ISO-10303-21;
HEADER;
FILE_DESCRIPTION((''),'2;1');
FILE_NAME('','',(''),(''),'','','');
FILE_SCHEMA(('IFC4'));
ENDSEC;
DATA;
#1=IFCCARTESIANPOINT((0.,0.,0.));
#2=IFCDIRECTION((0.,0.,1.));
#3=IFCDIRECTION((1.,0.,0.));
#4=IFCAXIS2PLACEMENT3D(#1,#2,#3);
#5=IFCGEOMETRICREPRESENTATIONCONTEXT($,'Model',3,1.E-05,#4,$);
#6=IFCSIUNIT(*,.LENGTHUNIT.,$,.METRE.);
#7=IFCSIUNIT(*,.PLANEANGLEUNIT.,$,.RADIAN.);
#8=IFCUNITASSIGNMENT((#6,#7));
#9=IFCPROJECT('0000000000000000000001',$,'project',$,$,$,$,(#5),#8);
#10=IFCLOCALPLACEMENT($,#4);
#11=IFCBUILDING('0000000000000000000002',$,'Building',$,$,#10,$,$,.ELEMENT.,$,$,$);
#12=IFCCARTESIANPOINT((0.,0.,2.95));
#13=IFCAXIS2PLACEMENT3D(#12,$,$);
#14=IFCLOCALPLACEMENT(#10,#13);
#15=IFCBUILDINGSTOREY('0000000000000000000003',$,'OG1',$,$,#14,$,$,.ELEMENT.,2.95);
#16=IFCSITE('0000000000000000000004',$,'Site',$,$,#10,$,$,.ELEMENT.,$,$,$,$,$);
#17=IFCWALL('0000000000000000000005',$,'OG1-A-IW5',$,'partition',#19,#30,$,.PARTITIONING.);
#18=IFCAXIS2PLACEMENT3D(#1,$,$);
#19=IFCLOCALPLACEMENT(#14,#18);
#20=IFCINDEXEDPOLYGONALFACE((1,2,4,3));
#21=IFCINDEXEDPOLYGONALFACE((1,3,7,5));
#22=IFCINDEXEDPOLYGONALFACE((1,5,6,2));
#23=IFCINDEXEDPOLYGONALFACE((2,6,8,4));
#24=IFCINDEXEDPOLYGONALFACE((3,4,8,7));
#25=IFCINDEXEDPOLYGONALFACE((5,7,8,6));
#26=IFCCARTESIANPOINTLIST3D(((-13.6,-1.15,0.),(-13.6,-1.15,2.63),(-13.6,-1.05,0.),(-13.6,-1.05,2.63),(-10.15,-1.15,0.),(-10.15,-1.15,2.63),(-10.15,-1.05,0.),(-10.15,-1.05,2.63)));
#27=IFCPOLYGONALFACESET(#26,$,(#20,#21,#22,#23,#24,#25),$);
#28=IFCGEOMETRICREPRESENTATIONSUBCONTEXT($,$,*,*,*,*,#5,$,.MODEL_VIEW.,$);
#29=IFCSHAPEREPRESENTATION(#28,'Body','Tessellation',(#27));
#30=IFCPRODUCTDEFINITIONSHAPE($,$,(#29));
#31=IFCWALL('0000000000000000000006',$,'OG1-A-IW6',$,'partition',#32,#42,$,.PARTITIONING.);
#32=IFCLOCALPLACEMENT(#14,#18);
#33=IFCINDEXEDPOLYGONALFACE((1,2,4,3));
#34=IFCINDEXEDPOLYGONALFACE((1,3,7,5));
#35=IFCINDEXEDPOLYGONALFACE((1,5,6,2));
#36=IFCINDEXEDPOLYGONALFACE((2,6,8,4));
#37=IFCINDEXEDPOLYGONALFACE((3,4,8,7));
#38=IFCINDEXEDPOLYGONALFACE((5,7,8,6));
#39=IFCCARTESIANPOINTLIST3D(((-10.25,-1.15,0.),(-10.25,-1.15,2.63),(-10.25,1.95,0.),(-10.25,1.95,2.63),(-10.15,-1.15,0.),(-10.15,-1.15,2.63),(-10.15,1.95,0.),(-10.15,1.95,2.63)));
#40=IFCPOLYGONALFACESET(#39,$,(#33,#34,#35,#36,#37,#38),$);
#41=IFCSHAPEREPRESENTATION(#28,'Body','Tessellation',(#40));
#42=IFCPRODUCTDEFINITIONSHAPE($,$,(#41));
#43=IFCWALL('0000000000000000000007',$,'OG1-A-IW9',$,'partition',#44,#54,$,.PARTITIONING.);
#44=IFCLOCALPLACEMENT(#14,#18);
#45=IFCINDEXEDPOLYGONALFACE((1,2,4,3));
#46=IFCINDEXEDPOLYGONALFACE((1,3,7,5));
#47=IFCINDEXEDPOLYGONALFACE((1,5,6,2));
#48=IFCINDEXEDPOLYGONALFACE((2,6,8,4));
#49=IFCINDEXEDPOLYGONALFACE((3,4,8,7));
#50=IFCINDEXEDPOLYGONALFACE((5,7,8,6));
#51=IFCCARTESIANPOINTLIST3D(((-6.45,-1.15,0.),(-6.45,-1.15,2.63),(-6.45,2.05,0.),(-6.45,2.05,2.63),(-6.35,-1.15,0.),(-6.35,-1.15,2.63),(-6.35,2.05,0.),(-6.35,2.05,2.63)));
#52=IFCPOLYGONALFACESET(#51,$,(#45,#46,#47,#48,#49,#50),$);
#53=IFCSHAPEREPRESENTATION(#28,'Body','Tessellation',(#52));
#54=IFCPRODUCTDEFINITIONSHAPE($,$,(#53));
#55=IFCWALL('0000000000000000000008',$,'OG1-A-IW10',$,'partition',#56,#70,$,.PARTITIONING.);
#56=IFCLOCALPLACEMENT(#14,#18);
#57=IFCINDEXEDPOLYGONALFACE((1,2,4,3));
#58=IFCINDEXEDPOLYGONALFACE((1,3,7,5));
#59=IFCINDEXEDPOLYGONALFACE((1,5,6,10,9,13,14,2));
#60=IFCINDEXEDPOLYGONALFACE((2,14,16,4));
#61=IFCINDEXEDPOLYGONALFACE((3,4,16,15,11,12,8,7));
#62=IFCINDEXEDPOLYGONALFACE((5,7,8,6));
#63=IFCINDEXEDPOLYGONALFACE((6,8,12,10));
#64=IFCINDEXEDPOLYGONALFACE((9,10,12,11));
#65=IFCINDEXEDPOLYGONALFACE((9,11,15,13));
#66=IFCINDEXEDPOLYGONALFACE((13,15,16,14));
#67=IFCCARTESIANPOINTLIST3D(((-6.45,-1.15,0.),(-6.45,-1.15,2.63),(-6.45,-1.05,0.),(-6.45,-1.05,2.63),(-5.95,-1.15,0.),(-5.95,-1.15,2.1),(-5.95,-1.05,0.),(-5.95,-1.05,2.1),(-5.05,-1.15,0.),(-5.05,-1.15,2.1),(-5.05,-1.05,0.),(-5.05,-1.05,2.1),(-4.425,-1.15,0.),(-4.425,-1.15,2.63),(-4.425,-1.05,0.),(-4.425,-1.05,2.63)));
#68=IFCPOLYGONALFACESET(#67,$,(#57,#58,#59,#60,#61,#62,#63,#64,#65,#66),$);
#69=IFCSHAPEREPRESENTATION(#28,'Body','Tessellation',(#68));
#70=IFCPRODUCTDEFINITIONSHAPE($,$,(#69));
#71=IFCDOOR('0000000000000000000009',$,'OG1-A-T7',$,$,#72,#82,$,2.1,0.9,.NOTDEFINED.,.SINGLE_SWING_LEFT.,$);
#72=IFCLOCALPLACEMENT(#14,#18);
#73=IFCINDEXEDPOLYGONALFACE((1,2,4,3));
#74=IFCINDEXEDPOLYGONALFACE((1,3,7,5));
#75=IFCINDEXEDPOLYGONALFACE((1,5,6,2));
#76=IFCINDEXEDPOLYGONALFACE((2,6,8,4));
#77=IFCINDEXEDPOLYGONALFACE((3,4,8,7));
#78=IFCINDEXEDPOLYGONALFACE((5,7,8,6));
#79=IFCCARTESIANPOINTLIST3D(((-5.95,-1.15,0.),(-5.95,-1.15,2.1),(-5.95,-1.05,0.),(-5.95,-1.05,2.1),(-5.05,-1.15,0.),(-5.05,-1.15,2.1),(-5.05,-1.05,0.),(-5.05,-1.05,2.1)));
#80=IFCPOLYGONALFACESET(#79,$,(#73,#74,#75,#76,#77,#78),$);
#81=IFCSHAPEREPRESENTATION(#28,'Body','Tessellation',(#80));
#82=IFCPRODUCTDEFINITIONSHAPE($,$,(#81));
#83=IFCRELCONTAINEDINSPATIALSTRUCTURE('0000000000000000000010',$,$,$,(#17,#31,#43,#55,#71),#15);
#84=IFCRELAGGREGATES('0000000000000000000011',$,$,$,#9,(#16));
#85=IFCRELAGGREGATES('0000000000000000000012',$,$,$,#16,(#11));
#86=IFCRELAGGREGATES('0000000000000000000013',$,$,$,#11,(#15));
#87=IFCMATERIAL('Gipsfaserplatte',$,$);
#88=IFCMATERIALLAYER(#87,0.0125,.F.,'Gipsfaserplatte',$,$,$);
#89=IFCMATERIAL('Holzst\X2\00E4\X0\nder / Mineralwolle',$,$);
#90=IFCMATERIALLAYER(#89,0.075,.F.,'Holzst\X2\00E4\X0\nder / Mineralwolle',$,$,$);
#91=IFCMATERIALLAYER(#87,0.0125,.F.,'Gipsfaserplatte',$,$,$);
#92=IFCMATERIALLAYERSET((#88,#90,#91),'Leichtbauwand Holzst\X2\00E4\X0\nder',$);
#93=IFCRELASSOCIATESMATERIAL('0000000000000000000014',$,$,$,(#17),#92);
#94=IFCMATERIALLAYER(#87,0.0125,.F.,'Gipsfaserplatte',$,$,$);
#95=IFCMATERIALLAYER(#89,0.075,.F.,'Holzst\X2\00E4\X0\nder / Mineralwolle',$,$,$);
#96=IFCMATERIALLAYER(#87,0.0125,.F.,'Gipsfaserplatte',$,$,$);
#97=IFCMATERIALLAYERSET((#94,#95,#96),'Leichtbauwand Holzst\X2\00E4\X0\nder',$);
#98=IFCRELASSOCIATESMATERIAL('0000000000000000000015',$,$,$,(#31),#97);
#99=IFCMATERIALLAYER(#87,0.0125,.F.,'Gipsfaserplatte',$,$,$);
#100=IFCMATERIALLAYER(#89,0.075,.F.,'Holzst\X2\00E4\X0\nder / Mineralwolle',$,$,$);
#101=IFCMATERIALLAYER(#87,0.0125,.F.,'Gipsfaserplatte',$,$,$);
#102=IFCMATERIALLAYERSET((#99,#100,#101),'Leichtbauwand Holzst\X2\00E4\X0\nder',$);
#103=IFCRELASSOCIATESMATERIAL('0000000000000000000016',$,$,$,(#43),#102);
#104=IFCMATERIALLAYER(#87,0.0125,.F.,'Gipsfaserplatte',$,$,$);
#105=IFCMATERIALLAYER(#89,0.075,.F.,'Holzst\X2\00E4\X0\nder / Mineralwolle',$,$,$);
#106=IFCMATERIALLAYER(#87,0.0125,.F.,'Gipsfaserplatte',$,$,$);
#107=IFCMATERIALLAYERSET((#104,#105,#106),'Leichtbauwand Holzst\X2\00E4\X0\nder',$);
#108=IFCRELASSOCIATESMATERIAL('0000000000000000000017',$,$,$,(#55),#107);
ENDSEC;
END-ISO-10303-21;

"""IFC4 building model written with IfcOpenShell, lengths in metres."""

from ifc_helpers import new_model, si_unit, frame, frame_2d, origin, origin_with_axes, place, context, subcontext, project, spatial, rectangle, extrude, material, layer, layer_set, element, fill, save


model = new_model("IFC4")

# Units and contexts
model_context = context("Model", 3, precision=1e-05, world=origin_with_axes())
sub_context = subcontext(model_context, None, None, "MODEL_VIEW")
ifc_project = project(units=[si_unit("LENGTHUNIT", "METRE"), si_unit("PLANEANGLEUNIT", "RADIAN")], contexts=[model_context])

# Site, building, storey
placement = place(None, origin_with_axes())
site = spatial("IfcSite", under=ifc_project, at=placement, Name="Site", CompositionType="ELEMENT")
building = spatial("IfcBuilding", under=site, at=placement, Name="Building", CompositionType="ELEMENT")
storey_placement = place(placement, frame((0.0, 0.0, 2.95)))
storey = spatial("IfcBuildingStorey", under=building, at=storey_placement, Name="OG1", CompositionType="ELEMENT", Elevation=2.95)

# Shared definitions
ifc_material_1 = material(Name="Gipsfaserplatte")

# Walls
ifc_layer_1 = layer(ifc_material_1, 0.0125, ventilated=False, Name="Gipsfaserplatte")
ifc_material_2 = material(Name="Holzständer / Mineralwolle")
ifc_layer_2 = layer(ifc_material_2, 0.075, ventilated=False, Name="Holzständer / Mineralwolle")
ifc_layer_3 = layer(ifc_material_1, 0.0125, ventilated=False, Name="Gipsfaserplatte")
ifc_layer_set_1 = layer_set([ifc_layer_1, ifc_layer_2, ifc_layer_3], Name="Leichtbauwand Holzständer")
wall_1_placement = place(storey_placement, frame((-13.6, -1.1, 0.0), z_axis=(0.0, 0.0, 1.0), x_axis=(1.0, 0.0, 0.0)))
element("IfcWall", 1, at=wall_1_placement, inside=storey, material=ifc_layer_set_1, Name="OG1-A-IW5", ObjectType="partition", PredefinedType="PARTITIONING", context=sub_context, shape_type="SweptSolid", body=[
    extrude(rectangle(XDim=3.45, YDim=0.1, at=frame_2d((1.725, 0.0))), origin(), (0.0, 0.0, 1.0), 2.63),
])
ifc_layer_4 = layer(ifc_material_1, 0.0125, ventilated=False, Name="Gipsfaserplatte")
ifc_layer_5 = layer(ifc_material_2, 0.075, ventilated=False, Name="Holzständer / Mineralwolle")
ifc_layer_6 = layer(ifc_material_1, 0.0125, ventilated=False, Name="Gipsfaserplatte")
ifc_layer_set_2 = layer_set([ifc_layer_4, ifc_layer_5, ifc_layer_6], Name="Leichtbauwand Holzständer")
wall_2_placement = place(storey_placement, frame((-10.2, -1.15, 0.0), z_axis=(0.0, 0.0, 1.0), x_axis=(0.0, 1.0, 0.0)))
element("IfcWall", 2, at=wall_2_placement, inside=storey, material=ifc_layer_set_2, Name="OG1-A-IW6", ObjectType="partition", PredefinedType="PARTITIONING", context=sub_context, shape_type="SweptSolid", body=[
    extrude(rectangle(XDim=3.1, YDim=0.1, at=frame_2d((1.55, 0.0))), origin(), (0.0, 0.0, 1.0), 2.63),
])
ifc_layer_7 = layer(ifc_material_1, 0.0125, ventilated=False, Name="Gipsfaserplatte")
ifc_layer_8 = layer(ifc_material_2, 0.075, ventilated=False, Name="Holzständer / Mineralwolle")
ifc_layer_9 = layer(ifc_material_1, 0.0125, ventilated=False, Name="Gipsfaserplatte")
ifc_layer_set_3 = layer_set([ifc_layer_7, ifc_layer_8, ifc_layer_9], Name="Leichtbauwand Holzständer")
wall_3_placement = place(storey_placement, frame((-6.4, -1.15, 0.0), z_axis=(0.0, 0.0, 1.0), x_axis=(0.0, 1.0, 0.0)))
element("IfcWall", 3, at=wall_3_placement, inside=storey, material=ifc_layer_set_3, Name="OG1-A-IW9", ObjectType="partition", PredefinedType="PARTITIONING", context=sub_context, shape_type="SweptSolid", body=[
    extrude(rectangle(XDim=3.2, YDim=0.1, at=frame_2d((1.6, 0.0))), origin(), (0.0, 0.0, 1.0), 2.63),
])

# Wall, opening, door
ifc_layer_10 = layer(ifc_material_1, 0.0125, ventilated=False, Name="Gipsfaserplatte")
ifc_layer_11 = layer(ifc_material_2, 0.075, ventilated=False, Name="Holzständer / Mineralwolle")
ifc_layer_12 = layer(ifc_material_1, 0.0125, ventilated=False, Name="Gipsfaserplatte")
ifc_layer_set_4 = layer_set([ifc_layer_10, ifc_layer_11, ifc_layer_12], Name="Leichtbauwand Holzständer")
wall_4_placement = place(storey_placement, frame((-6.45, -1.1, 0.0), z_axis=(0.0, 0.0, 1.0), x_axis=(1.0, 0.0, 0.0)))
wall_4 = element("IfcWall", 4, at=wall_4_placement, inside=storey, material=ifc_layer_set_4, Name="OG1-A-IW10", ObjectType="partition", PredefinedType="PARTITIONING", context=sub_context, shape_type="SweptSolid", body=[
    extrude(rectangle(XDim=2.025, YDim=0.1, at=frame_2d((1.0125, 0.0))), origin(), (0.0, 0.0, 1.0), 2.63),
])
opening_1_placement = place(wall_4_placement, frame((0.95, 0.1, 0.0), z_axis=(0.0, -1.0, 0.0), x_axis=(1.0, 0.0, 0.0)))
opening_1 = element("IfcOpeningElement", 5, at=opening_1_placement, cuts=wall_4, PredefinedType="OPENING", context=sub_context, shape_type="SweptSolid", body=[
    extrude(rectangle(XDim=0.9, YDim=2.1, at=frame_2d((0.0, 1.05))), origin(), (0.0, 0.0, 1.0), 0.2),
])
door_1_placement = place(wall_4_placement, frame((0.95, 0.05, 0.0), z_axis=(0.0, -1.0, 0.0), x_axis=(1.0, 0.0, 0.0)))
door_1 = element("IfcDoor", 6, at=door_1_placement, inside=storey, Name="OG1-A-T7", OperationType="SINGLE_SWING_LEFT", OverallHeight=2.1, OverallWidth=0.9, PredefinedType="NOTDEFINED", context=sub_context, shape_type="SweptSolid", body=[
    extrude(rectangle(XDim=0.9, YDim=2.1, at=frame_2d((0.0, 1.05))), origin(), (0.0, 0.0, 1.0), 0.1),
])
fill(opening_1, door_1)

save(model, "model.ifc")
